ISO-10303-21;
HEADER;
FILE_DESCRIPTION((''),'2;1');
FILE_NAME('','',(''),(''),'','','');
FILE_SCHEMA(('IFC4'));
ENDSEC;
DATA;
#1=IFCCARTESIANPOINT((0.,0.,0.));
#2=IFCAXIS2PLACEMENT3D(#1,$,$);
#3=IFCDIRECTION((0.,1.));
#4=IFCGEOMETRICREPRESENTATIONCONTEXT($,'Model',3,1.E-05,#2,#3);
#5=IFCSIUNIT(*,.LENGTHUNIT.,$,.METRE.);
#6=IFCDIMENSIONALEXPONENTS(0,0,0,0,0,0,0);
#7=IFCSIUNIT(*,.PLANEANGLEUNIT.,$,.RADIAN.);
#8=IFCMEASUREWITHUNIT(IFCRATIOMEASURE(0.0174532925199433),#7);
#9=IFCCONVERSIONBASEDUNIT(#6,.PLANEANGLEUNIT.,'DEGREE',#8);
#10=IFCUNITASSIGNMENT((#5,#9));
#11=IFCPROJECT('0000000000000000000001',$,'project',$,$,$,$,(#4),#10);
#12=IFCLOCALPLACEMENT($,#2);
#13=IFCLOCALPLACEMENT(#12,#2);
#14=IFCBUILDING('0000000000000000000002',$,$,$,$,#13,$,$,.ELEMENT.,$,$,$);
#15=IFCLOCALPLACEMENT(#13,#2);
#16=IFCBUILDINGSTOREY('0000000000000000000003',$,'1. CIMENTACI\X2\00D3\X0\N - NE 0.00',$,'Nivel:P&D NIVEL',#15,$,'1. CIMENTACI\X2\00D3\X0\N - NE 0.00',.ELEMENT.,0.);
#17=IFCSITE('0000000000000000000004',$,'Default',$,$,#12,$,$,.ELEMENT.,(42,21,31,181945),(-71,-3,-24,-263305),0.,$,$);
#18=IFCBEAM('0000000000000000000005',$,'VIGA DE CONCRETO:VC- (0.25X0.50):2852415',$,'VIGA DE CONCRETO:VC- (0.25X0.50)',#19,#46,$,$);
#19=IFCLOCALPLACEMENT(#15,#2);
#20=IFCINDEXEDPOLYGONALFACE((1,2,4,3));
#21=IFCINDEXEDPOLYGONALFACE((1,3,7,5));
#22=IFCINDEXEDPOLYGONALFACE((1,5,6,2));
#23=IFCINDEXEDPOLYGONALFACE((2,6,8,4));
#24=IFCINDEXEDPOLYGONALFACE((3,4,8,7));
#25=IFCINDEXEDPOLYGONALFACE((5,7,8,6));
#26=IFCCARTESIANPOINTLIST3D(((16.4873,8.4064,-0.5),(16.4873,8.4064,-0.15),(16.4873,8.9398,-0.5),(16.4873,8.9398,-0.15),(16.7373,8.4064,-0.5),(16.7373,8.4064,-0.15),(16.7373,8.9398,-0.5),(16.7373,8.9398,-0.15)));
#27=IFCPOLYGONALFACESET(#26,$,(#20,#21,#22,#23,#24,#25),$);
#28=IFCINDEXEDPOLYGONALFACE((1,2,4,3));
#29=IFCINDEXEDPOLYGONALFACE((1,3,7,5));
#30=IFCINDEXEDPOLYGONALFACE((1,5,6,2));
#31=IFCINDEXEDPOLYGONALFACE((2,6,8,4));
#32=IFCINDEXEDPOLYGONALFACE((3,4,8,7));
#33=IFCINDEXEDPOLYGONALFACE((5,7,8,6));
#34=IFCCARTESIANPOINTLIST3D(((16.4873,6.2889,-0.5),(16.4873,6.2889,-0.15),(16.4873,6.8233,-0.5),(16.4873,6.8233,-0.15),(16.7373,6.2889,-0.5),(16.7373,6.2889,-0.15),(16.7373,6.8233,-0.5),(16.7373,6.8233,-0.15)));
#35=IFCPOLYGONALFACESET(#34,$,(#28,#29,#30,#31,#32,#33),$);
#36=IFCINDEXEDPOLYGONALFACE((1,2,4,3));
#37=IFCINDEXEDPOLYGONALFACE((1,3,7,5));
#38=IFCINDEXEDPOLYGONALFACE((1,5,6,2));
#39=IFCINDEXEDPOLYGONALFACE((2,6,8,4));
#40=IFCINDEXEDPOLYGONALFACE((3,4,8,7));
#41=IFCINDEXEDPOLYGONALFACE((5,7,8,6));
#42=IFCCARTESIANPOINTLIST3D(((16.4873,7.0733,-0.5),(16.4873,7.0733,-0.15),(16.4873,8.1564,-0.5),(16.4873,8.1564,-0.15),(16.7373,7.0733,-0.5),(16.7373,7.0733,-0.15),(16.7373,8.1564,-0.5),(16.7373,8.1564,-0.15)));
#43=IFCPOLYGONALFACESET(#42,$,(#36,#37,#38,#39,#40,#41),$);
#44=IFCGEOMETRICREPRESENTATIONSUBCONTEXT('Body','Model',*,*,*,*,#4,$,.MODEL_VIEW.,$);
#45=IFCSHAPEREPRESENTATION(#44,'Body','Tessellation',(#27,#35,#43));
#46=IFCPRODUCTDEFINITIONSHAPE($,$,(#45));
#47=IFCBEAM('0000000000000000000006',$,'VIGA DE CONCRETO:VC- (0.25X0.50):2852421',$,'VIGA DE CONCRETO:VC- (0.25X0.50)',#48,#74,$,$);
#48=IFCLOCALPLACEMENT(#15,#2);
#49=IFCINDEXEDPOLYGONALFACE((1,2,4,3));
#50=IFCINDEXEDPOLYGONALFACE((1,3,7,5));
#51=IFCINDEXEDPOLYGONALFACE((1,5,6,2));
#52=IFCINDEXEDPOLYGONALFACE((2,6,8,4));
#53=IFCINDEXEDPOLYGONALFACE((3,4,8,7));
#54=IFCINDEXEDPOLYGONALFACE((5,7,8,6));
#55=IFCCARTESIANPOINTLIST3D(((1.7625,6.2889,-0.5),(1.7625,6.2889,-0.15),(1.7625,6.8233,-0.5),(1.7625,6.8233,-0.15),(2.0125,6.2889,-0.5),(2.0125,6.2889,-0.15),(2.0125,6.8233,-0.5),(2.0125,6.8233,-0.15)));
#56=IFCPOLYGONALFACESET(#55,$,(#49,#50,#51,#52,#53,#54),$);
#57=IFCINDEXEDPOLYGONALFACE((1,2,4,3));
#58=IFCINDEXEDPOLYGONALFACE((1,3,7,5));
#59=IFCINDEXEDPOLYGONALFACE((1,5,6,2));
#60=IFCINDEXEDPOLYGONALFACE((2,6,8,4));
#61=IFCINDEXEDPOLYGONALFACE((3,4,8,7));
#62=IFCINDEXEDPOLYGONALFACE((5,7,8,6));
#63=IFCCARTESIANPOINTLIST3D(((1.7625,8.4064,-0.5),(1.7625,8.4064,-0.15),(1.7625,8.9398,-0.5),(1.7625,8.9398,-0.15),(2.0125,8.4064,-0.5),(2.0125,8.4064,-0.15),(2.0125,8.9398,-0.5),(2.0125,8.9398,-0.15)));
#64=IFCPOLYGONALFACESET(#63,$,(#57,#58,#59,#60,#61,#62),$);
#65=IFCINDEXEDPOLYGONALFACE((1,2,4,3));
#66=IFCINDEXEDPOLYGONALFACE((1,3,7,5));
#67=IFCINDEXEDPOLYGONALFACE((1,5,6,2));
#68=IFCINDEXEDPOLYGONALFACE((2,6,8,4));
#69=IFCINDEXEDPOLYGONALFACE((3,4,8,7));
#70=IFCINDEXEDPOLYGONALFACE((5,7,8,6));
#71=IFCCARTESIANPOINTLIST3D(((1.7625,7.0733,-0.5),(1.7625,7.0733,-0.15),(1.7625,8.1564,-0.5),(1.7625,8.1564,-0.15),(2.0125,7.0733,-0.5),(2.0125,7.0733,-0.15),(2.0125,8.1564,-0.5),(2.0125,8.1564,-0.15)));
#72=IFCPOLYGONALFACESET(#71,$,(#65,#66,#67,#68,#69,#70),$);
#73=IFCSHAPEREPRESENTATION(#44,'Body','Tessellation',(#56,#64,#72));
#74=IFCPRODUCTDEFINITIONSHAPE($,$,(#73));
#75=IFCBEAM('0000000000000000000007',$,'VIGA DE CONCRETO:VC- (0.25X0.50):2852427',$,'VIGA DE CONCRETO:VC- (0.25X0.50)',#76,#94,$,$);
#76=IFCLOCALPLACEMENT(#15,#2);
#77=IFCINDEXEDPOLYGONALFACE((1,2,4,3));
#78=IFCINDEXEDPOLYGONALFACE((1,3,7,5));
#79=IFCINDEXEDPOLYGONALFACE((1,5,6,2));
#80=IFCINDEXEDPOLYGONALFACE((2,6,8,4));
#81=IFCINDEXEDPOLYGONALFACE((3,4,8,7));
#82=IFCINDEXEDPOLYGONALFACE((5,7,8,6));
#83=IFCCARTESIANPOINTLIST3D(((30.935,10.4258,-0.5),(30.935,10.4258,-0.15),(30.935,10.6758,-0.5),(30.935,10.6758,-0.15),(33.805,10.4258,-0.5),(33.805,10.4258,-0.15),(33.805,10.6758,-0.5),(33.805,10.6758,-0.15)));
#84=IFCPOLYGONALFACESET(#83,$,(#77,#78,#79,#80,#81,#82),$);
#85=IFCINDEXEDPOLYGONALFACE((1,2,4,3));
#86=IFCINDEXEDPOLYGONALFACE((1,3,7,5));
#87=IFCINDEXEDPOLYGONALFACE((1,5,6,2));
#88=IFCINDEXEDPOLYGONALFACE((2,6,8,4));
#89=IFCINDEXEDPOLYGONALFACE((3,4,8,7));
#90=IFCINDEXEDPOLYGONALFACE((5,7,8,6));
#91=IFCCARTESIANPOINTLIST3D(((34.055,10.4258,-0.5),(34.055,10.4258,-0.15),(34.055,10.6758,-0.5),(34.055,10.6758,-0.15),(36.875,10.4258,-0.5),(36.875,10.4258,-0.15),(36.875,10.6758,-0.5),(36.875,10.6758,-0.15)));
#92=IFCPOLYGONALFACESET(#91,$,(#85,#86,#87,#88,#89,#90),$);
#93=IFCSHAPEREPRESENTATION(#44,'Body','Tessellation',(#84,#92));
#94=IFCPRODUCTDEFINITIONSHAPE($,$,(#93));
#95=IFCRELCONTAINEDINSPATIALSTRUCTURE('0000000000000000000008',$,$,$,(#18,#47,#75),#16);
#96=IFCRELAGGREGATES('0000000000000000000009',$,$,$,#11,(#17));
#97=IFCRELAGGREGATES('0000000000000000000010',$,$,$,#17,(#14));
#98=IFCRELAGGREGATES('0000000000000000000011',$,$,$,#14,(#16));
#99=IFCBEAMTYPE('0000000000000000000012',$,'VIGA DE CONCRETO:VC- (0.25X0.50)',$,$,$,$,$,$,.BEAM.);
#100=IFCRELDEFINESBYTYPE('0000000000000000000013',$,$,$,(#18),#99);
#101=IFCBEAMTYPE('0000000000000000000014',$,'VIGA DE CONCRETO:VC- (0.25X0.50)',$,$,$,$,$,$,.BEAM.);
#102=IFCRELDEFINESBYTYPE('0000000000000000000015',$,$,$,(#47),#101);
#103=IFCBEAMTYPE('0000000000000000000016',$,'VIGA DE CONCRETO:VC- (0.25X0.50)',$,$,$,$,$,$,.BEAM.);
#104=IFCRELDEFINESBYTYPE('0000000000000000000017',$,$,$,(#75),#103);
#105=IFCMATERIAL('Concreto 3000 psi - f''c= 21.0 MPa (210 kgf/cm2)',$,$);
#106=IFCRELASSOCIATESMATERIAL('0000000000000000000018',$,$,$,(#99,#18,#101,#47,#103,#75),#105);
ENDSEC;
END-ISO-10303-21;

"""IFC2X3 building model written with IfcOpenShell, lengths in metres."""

from ifc_helpers import new_model, entity, si_unit, converted_unit, direction, frame, frame_2d, origin, place, context, subcontext, project, spatial, rectangle, extrude, source, transform, mapped, material, type_object, type_shapes, element, save


model = new_model("IFC2X3")

# Units and contexts
model_context = context("Model", 3, precision=1e-05, world=origin(), true_north=direction((0.0, 1.0)))
body_context = subcontext(model_context, "Body", "Model", "MODEL_VIEW")
ifc_project = project(units=[si_unit("LENGTHUNIT", "METRE"), converted_unit("PLANEANGLEUNIT", "DEGREE", entity("IfcRatioMeasure", 0.0174532925199433), si_unit("PLANEANGLEUNIT", "RADIAN"), dimensions=[0, 0, 0, 0, 0, 0, 0])], contexts=[model_context])

# Site, building, storey
site_placement = place(None, origin())
site = spatial("IfcSite", under=ifc_project, at=site_placement, Name="Default", CompositionType="ELEMENT", RefLatitude=(42, 21, 31, 181945), RefLongitude=(-71, -3, -24, -263305), RefElevation=0.0)
building_placement = place(site_placement, origin())
building = spatial("IfcBuilding", under=site, at=building_placement, CompositionType="ELEMENT")
storey_placement = place(building_placement, origin())
storey = spatial("IfcBuildingStorey", under=building, at=storey_placement, Name="1. CIMENTACIÓN - NE 0.00", ObjectType="Nivel:P&D NIVEL", LongName="1. CIMENTACIÓN - NE 0.00", CompositionType="ELEMENT", Elevation=0.0)

# Beams
ifc_material = material(Name="Concreto 3000 psi - f'c= 21.0 MPa (210 kgf/cm2)")
beam_type_1 = type_object("IfcBeamType", Name="VIGA DE CONCRETO:VC- (0.25X0.50)", PredefinedType="BEAM", material=ifc_material)
shared_shape_1 = source(origin(), body_context, "Body", "SweptSolid", [
    extrude(rectangle(XDim=0.35, YDim=0.25, at=frame_2d((0.0, 0.0), x_axis=(0.0, 1.0))), frame((16.6123, 8.9398, -0.325), z_axis=(0.0, -1.0, 0.0), x_axis=(-1.0, 0.0, 0.0)), (0.0, 0.0, 1.0), 0.5334),
    extrude(rectangle(XDim=0.35, YDim=0.25, at=frame_2d((0.0, 0.0), x_axis=(0.0, 1.0))), frame((16.6123, 6.8233, -0.325), z_axis=(0.0, -1.0, 0.0), x_axis=(-1.0, 0.0, 0.0)), (0.0, 0.0, 1.0), 0.5344),
    extrude(rectangle(XDim=0.35, YDim=0.25, at=frame_2d((0.0, 0.0), x_axis=(0.0, 1.0))), frame((16.6123, 8.1564, -0.325), z_axis=(0.0, -1.0, 0.0), x_axis=(-1.0, 0.0, 0.0)), (0.0, 0.0, 1.0), 1.0831),
])
type_shapes(beam_type_1, [shared_shape_1])
beam_1_placement = place(storey_placement, origin())
element("IfcBeam", 1, at=beam_1_placement, inside=storey, type_object=beam_type_1, material=ifc_material, Name="VIGA DE CONCRETO:VC- (0.25X0.50):2852415", ObjectType="VIGA DE CONCRETO:VC- (0.25X0.50)", context=body_context, shape_type="MappedRepresentation", body=[
    mapped(shared_shape_1, transform((0.0, 0.0, 0.0), scale=1.0)),
])
beam_type_2 = type_object("IfcBeamType", Name="VIGA DE CONCRETO:VC- (0.25X0.50)", PredefinedType="BEAM", material=ifc_material)
shared_shape_2 = source(origin(), body_context, "Body", "SweptSolid", [
    extrude(rectangle(XDim=0.35, YDim=0.25, at=frame_2d((0.0, 0.0), x_axis=(0.0, 1.0))), frame((1.8875, 6.8233, -0.325), z_axis=(0.0, -1.0, 0.0), x_axis=(-1.0, 0.0, 0.0)), (0.0, 0.0, 1.0), 0.5344),
    extrude(rectangle(XDim=0.35, YDim=0.25, at=frame_2d((0.0, 0.0), x_axis=(0.0, 1.0))), frame((1.8875, 8.9398, -0.325), z_axis=(0.0, -1.0, 0.0), x_axis=(-1.0, 0.0, 0.0)), (0.0, 0.0, 1.0), 0.5334),
    extrude(rectangle(XDim=0.35, YDim=0.25, at=frame_2d((0.0, 0.0), x_axis=(0.0, 1.0))), frame((1.8875, 8.1564, -0.325), z_axis=(0.0, -1.0, 0.0), x_axis=(-1.0, 0.0, 0.0)), (0.0, 0.0, 1.0), 1.0831),
])
type_shapes(beam_type_2, [shared_shape_2])
beam_2_placement = place(storey_placement, origin())
element("IfcBeam", 2, at=beam_2_placement, inside=storey, type_object=beam_type_2, material=ifc_material, Name="VIGA DE CONCRETO:VC- (0.25X0.50):2852421", ObjectType="VIGA DE CONCRETO:VC- (0.25X0.50)", context=body_context, shape_type="MappedRepresentation", body=[
    mapped(shared_shape_2, transform((0.0, 0.0, 0.0), scale=1.0)),
])
beam_type_3 = type_object("IfcBeamType", Name="VIGA DE CONCRETO:VC- (0.25X0.50)", PredefinedType="BEAM", material=ifc_material)
shared_shape_3 = source(origin(), body_context, "Body", "SweptSolid", [
    extrude(rectangle(XDim=0.35, YDim=0.25, at=frame_2d((0.0, 0.0), x_axis=(1.0, 0.0))), frame((33.805, 10.5508, -0.325), z_axis=(-1.0, 0.0, 0.0), x_axis=(0.0, 0.0, -1.0)), (0.0, 0.0, 1.0), 2.87),
    extrude(rectangle(XDim=0.35, YDim=0.25, at=frame_2d((0.0, 0.0), x_axis=(1.0, 0.0))), frame((36.875, 10.5508, -0.325), z_axis=(-1.0, 0.0, 0.0), x_axis=(0.0, 0.0, -1.0)), (0.0, 0.0, 1.0), 2.82),
])
type_shapes(beam_type_3, [shared_shape_3])
beam_3_placement = place(storey_placement, origin())
element("IfcBeam", 3, at=beam_3_placement, inside=storey, type_object=beam_type_3, material=ifc_material, Name="VIGA DE CONCRETO:VC- (0.25X0.50):2852427", ObjectType="VIGA DE CONCRETO:VC- (0.25X0.50)", context=body_context, shape_type="MappedRepresentation", body=[
    mapped(shared_shape_3, transform((0.0, 0.0, 0.0), scale=1.0)),
])

save(model, "model.ifc")
